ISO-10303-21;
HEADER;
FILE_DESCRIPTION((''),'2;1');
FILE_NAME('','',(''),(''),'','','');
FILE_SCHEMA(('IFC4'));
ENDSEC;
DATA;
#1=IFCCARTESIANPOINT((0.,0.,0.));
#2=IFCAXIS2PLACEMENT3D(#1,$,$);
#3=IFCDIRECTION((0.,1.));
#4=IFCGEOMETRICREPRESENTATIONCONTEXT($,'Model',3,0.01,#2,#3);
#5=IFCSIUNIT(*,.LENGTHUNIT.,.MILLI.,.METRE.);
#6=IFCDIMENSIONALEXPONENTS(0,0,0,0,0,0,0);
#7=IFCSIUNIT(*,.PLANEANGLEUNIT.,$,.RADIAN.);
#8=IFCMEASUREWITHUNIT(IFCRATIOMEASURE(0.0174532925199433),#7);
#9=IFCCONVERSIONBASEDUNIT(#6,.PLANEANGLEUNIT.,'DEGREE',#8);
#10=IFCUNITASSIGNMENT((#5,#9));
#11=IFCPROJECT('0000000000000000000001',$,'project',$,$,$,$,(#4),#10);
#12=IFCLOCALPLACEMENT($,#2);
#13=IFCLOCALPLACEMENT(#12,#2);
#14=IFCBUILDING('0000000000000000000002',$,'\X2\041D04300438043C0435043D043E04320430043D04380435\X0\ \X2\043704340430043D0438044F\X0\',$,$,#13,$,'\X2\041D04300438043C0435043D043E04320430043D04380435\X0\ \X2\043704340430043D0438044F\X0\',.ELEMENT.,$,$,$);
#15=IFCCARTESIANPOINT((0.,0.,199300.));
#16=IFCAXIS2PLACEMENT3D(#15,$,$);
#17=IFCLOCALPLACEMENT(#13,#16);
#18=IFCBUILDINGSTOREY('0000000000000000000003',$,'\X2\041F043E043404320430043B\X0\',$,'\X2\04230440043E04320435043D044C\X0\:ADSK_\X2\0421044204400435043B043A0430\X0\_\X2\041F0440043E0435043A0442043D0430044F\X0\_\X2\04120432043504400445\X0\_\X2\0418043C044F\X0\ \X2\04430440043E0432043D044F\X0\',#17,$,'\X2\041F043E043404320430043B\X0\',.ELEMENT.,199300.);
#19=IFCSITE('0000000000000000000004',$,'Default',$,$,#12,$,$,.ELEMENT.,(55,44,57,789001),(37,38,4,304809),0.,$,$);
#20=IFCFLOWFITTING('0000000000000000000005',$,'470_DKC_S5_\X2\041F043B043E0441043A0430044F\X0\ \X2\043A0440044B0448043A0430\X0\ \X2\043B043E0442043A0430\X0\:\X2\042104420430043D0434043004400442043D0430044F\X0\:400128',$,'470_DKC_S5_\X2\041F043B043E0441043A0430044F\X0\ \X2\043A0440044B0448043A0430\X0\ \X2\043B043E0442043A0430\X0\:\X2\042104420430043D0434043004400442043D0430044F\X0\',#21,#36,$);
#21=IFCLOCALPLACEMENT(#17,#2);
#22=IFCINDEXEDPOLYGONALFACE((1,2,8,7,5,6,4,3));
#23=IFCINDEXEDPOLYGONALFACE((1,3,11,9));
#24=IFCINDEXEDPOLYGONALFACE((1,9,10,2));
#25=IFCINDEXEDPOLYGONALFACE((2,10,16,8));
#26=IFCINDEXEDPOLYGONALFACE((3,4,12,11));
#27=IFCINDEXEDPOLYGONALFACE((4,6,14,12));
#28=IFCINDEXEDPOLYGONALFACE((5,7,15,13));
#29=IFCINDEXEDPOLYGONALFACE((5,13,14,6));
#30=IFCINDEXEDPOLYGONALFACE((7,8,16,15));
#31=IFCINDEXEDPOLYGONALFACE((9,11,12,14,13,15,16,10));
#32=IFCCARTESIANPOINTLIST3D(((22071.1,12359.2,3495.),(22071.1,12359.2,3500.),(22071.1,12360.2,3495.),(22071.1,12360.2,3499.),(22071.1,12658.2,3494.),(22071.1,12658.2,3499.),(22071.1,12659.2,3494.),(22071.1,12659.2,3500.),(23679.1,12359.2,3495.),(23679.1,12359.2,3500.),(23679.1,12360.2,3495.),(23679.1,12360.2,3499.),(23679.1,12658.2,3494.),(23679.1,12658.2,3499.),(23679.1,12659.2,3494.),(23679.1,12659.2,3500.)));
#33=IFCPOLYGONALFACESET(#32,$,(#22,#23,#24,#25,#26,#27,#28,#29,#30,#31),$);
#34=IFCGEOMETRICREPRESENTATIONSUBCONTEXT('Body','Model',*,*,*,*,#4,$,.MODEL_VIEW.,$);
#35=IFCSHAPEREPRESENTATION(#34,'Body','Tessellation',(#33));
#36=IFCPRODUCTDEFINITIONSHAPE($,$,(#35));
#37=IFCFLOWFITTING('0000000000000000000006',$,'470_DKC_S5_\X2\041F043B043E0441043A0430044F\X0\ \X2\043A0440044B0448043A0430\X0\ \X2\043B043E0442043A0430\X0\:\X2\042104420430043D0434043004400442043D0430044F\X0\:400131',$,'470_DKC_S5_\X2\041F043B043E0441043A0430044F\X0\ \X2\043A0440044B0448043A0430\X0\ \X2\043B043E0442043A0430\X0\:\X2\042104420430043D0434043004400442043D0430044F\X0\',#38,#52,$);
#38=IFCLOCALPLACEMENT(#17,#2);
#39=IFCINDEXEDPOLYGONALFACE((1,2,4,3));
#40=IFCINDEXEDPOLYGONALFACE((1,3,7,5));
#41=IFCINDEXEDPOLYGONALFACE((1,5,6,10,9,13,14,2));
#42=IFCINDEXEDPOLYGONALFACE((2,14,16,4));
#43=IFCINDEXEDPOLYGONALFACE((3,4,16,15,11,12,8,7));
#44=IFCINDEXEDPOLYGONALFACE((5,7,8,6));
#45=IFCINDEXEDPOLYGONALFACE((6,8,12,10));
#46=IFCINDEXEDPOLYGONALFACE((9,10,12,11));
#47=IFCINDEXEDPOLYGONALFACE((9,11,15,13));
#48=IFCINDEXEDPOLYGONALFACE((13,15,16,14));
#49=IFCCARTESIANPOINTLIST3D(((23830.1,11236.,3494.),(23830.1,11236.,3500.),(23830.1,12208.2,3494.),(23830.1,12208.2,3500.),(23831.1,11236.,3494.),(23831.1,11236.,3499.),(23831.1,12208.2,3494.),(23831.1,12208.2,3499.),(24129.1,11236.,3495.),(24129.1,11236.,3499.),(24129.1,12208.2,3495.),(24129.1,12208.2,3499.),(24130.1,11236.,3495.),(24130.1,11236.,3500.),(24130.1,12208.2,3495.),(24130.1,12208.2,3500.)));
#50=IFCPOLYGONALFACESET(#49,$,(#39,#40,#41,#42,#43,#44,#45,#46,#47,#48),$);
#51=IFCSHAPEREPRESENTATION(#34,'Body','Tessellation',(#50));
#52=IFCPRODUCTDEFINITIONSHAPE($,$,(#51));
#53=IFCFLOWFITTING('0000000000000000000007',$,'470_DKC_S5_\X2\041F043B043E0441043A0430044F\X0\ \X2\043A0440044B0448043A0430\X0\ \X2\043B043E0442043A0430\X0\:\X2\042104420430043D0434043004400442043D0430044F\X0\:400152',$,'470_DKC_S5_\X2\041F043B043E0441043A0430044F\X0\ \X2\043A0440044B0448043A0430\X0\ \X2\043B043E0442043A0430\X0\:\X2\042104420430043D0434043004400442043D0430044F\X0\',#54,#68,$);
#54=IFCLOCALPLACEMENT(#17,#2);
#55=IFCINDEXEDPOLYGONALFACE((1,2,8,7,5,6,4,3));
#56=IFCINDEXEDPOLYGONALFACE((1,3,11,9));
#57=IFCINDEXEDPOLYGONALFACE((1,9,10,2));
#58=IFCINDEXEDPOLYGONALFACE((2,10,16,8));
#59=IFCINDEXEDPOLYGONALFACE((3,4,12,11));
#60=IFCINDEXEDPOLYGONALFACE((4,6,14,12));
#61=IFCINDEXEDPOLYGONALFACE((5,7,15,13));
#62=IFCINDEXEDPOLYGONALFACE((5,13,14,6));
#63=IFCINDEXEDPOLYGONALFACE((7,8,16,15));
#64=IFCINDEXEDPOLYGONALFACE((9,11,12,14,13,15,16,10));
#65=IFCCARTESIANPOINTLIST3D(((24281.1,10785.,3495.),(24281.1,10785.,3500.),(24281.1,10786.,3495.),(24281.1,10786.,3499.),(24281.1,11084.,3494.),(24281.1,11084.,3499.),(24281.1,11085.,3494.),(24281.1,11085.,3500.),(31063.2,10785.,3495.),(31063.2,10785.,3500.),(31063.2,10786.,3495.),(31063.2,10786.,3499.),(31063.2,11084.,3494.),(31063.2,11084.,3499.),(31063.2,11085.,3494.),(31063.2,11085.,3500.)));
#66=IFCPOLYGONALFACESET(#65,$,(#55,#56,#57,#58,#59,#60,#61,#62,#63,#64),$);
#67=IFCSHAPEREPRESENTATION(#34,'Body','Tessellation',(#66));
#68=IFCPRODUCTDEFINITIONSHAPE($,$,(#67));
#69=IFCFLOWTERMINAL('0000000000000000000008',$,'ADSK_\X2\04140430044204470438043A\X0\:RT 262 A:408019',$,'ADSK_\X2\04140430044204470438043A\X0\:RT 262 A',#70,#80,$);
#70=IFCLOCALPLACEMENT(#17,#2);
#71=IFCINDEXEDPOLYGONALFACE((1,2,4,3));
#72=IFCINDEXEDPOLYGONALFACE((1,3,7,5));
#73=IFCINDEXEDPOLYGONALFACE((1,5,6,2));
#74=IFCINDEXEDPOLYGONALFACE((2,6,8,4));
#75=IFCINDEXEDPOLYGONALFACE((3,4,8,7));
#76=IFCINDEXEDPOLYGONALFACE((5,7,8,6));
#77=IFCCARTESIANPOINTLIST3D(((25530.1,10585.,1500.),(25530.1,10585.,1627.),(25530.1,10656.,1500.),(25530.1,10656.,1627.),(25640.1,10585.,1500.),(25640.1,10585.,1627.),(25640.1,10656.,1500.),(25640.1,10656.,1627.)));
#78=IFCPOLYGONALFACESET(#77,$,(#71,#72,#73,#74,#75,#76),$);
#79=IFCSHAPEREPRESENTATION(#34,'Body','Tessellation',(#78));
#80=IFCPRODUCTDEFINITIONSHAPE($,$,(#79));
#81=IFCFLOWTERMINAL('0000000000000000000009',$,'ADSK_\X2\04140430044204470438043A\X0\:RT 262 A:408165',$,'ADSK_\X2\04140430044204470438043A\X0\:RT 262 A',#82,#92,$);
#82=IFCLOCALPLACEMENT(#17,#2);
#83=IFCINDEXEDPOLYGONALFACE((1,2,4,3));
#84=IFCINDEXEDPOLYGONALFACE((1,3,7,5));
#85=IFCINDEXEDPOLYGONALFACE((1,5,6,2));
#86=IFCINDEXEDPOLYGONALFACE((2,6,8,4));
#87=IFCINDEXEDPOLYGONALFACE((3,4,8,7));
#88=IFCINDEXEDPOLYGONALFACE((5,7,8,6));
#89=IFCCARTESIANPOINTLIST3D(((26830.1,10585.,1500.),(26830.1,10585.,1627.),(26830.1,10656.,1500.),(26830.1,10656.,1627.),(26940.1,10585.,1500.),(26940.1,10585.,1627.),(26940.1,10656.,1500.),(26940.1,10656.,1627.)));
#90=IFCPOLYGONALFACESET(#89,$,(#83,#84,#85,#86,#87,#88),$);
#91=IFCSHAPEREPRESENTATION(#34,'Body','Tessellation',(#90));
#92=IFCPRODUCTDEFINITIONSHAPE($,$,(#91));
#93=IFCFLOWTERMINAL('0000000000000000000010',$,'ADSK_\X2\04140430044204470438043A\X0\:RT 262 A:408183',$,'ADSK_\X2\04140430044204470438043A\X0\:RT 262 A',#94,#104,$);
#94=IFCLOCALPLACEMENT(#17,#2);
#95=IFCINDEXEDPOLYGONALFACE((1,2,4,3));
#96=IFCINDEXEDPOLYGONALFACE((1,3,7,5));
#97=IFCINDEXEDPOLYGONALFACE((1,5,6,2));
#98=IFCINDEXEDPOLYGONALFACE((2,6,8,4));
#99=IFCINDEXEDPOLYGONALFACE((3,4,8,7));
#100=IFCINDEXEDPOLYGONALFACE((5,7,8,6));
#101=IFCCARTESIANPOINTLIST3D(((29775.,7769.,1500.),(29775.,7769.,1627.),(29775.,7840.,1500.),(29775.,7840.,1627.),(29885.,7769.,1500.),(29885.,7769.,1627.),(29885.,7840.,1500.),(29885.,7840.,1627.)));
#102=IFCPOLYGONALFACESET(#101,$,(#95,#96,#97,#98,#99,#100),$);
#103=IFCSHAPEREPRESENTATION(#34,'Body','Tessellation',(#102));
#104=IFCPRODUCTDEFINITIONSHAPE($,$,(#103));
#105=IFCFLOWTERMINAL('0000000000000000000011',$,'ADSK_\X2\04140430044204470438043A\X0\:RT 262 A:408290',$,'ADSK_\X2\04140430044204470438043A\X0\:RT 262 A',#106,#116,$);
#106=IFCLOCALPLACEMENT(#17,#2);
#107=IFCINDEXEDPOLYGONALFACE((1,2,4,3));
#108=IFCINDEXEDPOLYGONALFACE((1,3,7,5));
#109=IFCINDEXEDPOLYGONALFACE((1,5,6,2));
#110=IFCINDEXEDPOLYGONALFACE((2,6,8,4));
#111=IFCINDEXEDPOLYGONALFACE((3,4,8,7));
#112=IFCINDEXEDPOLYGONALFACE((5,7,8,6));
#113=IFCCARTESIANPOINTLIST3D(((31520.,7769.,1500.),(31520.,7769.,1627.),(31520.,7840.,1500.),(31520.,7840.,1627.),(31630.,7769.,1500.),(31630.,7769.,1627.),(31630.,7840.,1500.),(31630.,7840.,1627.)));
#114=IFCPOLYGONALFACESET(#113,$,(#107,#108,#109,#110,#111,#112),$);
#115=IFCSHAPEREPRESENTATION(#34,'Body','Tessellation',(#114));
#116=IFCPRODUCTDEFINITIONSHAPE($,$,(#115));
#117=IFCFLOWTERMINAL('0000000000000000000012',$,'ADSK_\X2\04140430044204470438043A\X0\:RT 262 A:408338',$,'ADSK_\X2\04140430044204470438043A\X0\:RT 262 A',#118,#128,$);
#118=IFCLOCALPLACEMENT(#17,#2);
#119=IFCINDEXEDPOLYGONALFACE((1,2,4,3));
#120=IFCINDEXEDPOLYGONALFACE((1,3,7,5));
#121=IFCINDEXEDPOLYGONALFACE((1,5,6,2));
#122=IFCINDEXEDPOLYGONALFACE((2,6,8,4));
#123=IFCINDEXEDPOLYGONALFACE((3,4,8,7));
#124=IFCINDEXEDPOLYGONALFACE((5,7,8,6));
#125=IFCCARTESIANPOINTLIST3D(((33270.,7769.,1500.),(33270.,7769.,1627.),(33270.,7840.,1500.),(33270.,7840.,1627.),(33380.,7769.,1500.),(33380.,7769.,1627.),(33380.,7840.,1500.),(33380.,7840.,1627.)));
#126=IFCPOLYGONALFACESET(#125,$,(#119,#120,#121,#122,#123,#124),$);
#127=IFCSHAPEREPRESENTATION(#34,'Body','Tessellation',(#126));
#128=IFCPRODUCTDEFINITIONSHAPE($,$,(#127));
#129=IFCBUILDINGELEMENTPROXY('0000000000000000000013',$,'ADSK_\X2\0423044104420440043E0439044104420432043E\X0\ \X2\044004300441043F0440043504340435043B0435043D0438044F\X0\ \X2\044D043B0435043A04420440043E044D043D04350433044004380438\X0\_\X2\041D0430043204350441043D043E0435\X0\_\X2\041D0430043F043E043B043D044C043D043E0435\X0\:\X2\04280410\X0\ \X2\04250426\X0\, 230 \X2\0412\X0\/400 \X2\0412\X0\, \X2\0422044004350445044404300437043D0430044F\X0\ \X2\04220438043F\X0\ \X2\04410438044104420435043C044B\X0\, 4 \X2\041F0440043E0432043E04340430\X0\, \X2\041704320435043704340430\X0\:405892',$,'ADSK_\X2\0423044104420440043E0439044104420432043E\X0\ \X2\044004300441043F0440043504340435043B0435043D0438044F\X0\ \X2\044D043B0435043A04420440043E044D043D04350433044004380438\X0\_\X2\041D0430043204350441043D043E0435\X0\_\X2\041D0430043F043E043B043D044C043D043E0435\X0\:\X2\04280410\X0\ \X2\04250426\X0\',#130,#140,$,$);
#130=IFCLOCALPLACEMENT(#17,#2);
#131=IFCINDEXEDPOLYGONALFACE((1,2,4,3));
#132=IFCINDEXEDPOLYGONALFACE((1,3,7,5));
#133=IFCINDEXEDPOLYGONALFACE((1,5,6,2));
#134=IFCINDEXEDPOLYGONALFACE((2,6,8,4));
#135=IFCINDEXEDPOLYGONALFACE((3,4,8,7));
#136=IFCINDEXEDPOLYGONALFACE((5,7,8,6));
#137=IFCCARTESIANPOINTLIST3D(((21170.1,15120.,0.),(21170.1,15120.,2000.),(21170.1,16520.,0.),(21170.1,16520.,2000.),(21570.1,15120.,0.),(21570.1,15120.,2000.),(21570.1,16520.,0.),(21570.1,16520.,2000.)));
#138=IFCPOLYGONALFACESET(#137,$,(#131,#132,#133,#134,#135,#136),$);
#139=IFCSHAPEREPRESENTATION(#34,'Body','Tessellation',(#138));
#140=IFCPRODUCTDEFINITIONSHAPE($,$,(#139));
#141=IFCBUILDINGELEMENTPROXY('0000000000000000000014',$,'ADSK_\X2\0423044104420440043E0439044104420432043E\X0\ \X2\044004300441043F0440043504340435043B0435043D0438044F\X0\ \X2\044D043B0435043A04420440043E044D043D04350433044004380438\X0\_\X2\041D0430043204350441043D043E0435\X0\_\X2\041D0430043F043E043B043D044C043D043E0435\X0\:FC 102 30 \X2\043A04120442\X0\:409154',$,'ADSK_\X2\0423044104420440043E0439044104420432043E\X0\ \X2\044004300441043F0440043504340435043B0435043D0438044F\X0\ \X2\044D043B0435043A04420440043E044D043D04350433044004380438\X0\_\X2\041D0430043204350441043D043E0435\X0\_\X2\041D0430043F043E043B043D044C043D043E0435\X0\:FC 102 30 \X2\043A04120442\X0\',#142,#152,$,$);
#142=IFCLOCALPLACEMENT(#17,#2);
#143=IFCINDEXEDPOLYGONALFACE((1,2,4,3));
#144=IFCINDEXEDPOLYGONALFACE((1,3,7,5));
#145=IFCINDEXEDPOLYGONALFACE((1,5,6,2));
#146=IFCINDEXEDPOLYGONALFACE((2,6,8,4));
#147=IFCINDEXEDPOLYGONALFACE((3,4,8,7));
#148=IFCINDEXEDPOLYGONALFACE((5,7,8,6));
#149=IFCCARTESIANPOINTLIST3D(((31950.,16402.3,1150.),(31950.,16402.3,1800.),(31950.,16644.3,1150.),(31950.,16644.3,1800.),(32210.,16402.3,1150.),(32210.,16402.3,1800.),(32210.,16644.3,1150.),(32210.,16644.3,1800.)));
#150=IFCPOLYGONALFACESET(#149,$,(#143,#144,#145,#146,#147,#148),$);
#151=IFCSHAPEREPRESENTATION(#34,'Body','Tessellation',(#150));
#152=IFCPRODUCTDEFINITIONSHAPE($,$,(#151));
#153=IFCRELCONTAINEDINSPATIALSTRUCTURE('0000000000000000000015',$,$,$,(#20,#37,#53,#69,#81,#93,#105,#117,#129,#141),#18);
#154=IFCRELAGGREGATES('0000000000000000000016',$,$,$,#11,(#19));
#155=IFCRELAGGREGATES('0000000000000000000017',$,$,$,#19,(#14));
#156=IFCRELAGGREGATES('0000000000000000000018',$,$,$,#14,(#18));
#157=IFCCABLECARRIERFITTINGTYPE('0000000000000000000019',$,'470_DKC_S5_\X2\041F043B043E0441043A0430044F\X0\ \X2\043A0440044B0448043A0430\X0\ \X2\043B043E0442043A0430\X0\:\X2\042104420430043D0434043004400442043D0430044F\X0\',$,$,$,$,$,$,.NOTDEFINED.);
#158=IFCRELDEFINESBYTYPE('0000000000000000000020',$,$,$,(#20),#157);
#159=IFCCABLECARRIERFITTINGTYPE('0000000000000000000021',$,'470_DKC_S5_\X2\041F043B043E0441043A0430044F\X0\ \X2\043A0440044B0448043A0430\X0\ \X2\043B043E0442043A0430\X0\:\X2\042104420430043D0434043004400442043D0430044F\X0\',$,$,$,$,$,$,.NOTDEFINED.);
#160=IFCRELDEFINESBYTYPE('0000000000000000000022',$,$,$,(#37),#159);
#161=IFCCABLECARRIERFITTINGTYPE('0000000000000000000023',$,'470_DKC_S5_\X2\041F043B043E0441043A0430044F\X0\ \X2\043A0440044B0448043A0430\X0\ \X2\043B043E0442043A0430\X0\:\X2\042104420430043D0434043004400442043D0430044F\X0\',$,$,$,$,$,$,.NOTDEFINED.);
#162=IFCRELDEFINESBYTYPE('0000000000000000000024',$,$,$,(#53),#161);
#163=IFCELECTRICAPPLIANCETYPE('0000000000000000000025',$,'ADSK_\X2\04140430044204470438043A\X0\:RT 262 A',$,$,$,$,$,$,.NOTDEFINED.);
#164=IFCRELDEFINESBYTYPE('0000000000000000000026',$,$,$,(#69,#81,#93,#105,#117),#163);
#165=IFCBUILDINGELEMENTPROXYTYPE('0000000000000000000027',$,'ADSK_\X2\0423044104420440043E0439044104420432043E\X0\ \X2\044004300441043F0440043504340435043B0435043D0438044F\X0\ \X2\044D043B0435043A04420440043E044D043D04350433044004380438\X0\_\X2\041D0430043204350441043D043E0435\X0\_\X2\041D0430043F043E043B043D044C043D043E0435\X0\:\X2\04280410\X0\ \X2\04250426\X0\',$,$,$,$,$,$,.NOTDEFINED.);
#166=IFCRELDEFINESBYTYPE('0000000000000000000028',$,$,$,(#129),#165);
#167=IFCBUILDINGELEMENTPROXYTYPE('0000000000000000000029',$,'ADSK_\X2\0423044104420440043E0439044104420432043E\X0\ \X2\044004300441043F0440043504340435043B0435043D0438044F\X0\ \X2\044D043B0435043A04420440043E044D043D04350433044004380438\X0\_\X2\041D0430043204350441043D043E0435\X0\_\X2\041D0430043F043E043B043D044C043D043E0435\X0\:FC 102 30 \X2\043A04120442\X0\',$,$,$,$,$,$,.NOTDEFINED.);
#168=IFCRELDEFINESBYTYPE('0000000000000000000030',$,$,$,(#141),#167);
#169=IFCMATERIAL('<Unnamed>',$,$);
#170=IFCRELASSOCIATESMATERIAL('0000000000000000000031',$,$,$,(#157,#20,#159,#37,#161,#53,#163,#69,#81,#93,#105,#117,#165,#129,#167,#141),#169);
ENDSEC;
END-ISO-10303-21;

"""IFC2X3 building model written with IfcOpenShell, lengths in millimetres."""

from ifc_helpers import new_model, entity, si_unit, converted_unit, direction, frame, origin, origin_2d_with_axis, place, context, subcontext, project, spatial, polyline, rectangle, outline, extrude, source, transform, mapped, material, type_object, type_shapes, element, save


model = new_model("IFC2X3")

# Units and contexts
model_context = context("Model", 3, precision=0.01, world=origin(), true_north=direction((0.0, 1.0)))
body_context = subcontext(model_context, "Body", "Model", "MODEL_VIEW")
ifc_project = project(units=[si_unit("LENGTHUNIT", "METRE", prefix="MILLI"), converted_unit("PLANEANGLEUNIT", "DEGREE", entity("IfcRatioMeasure", 0.0174532925199433), si_unit("PLANEANGLEUNIT", "RADIAN"), dimensions=[0, 0, 0, 0, 0, 0, 0])], contexts=[model_context])

# Site, building, storey
site_placement = place(None, origin())
site = spatial("IfcSite", under=ifc_project, at=site_placement, Name="Default", CompositionType="ELEMENT", RefLatitude=(55, 44, 57, 789001), RefLongitude=(37, 38, 4, 304809), RefElevation=0.0)
building_placement = place(site_placement, origin())
building = spatial("IfcBuilding", under=site, at=building_placement, Name="Наименование здания", LongName="Наименование здания", CompositionType="ELEMENT")
storey_placement = place(building_placement, frame((0.0, 0.0, 199300.0)))
storey = spatial("IfcBuildingStorey", under=building, at=storey_placement, Name="Подвал", ObjectType="Уровень:ADSK_Стрелка_Проектная_Вверх_Имя уровня", LongName="Подвал", CompositionType="ELEMENT", Elevation=199300.0)

# Flow fittings
ifc_material = material(Name="<Unnamed>")
cable_carrier_fitting_type_1 = type_object("IfcCableCarrierFittingType", Name="470_DKC_S5_Плоская крышка лотка:Стандартная", PredefinedType="NOTDEFINED", material=ifc_material)
shared_shape_1 = source(origin(), body_context, "Body", "SweptSolid", [
    extrude(outline(polyline([(-150.0, -2.0), (-149.0, -2.0), (-149.0, 2.0), (149.0, 2.0), (149.0, -3.0), (150.0, -3.0), (150.0, 3.0), (-150.0, 3.0), (-150.0, -2.0)])), frame((0.0, 150.0, 3.0), z_axis=(1.0, 0.0, 0.0), x_axis=(0.0, 1.0, 0.0)), (0.0, 0.0, 1.0), 1608.0),
])
type_shapes(cable_carrier_fitting_type_1, [shared_shape_1])
flow_fitting_1_placement = place(storey_placement, frame((22071.1, 12359.2, 3494.0)))
element("IfcFlowFitting", 1, at=flow_fitting_1_placement, inside=storey, type_object=cable_carrier_fitting_type_1, material=ifc_material, Name="470_DKC_S5_Плоская крышка лотка:Стандартная:400128", ObjectType="470_DKC_S5_Плоская крышка лотка:Стандартная", context=body_context, shape_type="MappedRepresentation", body=[
    mapped(shared_shape_1, transform((0.0, 0.0, 0.0), scale=1.0)),
])
cable_carrier_fitting_type_2 = type_object("IfcCableCarrierFittingType", Name="470_DKC_S5_Плоская крышка лотка:Стандартная", PredefinedType="NOTDEFINED", material=ifc_material)
shared_shape_2 = source(origin(), body_context, "Body", "SweptSolid", [
    extrude(outline(polyline([(-150.0, -2.0), (-149.0, -2.0), (-149.0, 2.0), (149.0, 2.0), (149.0, -3.0), (150.0, -3.0), (150.0, 3.0), (-150.0, 3.0), (-150.0, -2.0)])), frame((0.0, 150.0, 3.0), z_axis=(1.0, 0.0, 0.0), x_axis=(0.0, 1.0, 0.0)), (0.0, 0.0, 1.0), 972.2),
])
type_shapes(cable_carrier_fitting_type_2, [shared_shape_2])
flow_fitting_2_placement = place(storey_placement, frame((24130.1, 11236.0, 3494.0), z_axis=(0.0, 0.0, 1.0), x_axis=(0.0, 1.0, 0.0)))
element("IfcFlowFitting", 2, at=flow_fitting_2_placement, inside=storey, type_object=cable_carrier_fitting_type_2, material=ifc_material, Name="470_DKC_S5_Плоская крышка лотка:Стандартная:400131", ObjectType="470_DKC_S5_Плоская крышка лотка:Стандартная", context=body_context, shape_type="MappedRepresentation", body=[
    mapped(shared_shape_2, transform((0.0, 0.0, 0.0), scale=1.0)),
])
cable_carrier_fitting_type_3 = type_object("IfcCableCarrierFittingType", Name="470_DKC_S5_Плоская крышка лотка:Стандартная", PredefinedType="NOTDEFINED", material=ifc_material)
shared_shape_3 = source(origin(), body_context, "Body", "SweptSolid", [
    extrude(outline(polyline([(-150.0, -2.0), (-149.0, -2.0), (-149.0, 2.0), (149.0, 2.0), (149.0, -3.0), (150.0, -3.0), (150.0, 3.0), (-150.0, 3.0), (-150.0, -2.0)])), frame((0.0, 150.0, 3.0), z_axis=(1.0, 0.0, 0.0), x_axis=(0.0, 1.0, 0.0)), (0.0, 0.0, 1.0), 6782.1),
])
type_shapes(cable_carrier_fitting_type_3, [shared_shape_3])
flow_fitting_3_placement = place(storey_placement, frame((24281.1, 10785.0, 3494.0)))
element("IfcFlowFitting", 3, at=flow_fitting_3_placement, inside=storey, type_object=cable_carrier_fitting_type_3, material=ifc_material, Name="470_DKC_S5_Плоская крышка лотка:Стандартная:400152", ObjectType="470_DKC_S5_Плоская крышка лотка:Стандартная", context=body_context, shape_type="MappedRepresentation", body=[
    mapped(shared_shape_3, transform((0.0, 0.0, 0.0), scale=1.0)),
])

# Flow terminals
electric_appliance_type = type_object("IfcElectricApplianceType", Name="ADSK_Датчик:RT 262 A", PredefinedType="NOTDEFINED", material=ifc_material)
shared_shape_4 = source(origin(), body_context, "Body", "SweptSolid", [
    extrude(rectangle(XDim=71.0, YDim=110.0, at=origin_2d_with_axis()), frame((0.0, 0.0, 0.0), z_axis=(0.0, 0.0, 1.0), x_axis=(-1.0, 0.0, 0.0)), (0.0, 0.0, 1.0), 127.0),
])
type_shapes(electric_appliance_type, [shared_shape_4])
for number, where, z_axis, x_axis, name in (
    (4, (25585.1, 10620.5, 1500.0), (0.0, 0.0, 1.0), (0.0, 1.0, 0.0), "ADSK_Датчик:RT 262 A:408019"),
    (5, (26885.1, 10620.5, 1500.0), (0.0, 0.0, 1.0), (0.0, 1.0, 0.0), "ADSK_Датчик:RT 262 A:408165"),
    (6, (29830.0, 7804.5, 1500.0), (0.0, 0.0, 1.0), (0.0, -1.0, 0.0), "ADSK_Датчик:RT 262 A:408183"),
    (7, (31575.0, 7804.5, 1500.0), (0.0, 0.0, 1.0), (0.0, -1.0, 0.0), "ADSK_Датчик:RT 262 A:408290"),
    (8, (33325.0, 7804.5, 1500.0), (0.0, 0.0, 1.0), (0.0, -1.0, 0.0), "ADSK_Датчик:RT 262 A:408338"),
):
    element("IfcFlowTerminal", number, at=place(storey_placement, frame(where, z_axis=z_axis, x_axis=x_axis)), inside=storey, type_object=electric_appliance_type, material=ifc_material, Name=name, ObjectType="ADSK_Датчик:RT 262 A", context=body_context, shape_type="MappedRepresentation", body=[
        mapped(shared_shape_4, transform((0.0, 0.0, 0.0), scale=1.0)),
    ])

# Building element proxies
building_element_proxy_type_1 = type_object("IfcBuildingElementProxyType", Name="ADSK_Устройство распределения электроэнегрии_Навесное_Наполньное:ША ХЦ", PredefinedType="NOTDEFINED", material=ifc_material)
shared_shape_5 = source(origin(), body_context, "Body", "SweptSolid", [
    extrude(rectangle(XDim=1400.0, YDim=400.0, at=origin_2d_with_axis()), frame((0.0, 200.0, -2000.0), z_axis=(0.0, 0.0, 1.0), x_axis=(-1.0, 0.0, 0.0)), (0.0, 0.0, 1.0), 2000.0),
])
type_shapes(building_element_proxy_type_1, [shared_shape_5])
proxy_1_placement = place(storey_placement, frame((21170.1, 15820.0, 2000.0), z_axis=(0.0, 0.0, 1.0), x_axis=(0.0, -1.0, 0.0)))
element("IfcBuildingElementProxy", 9, at=proxy_1_placement, inside=storey, type_object=building_element_proxy_type_1, material=ifc_material, Name="ADSK_Устройство распределения электроэнегрии_Навесное_Наполньное:ША ХЦ, 230 В/400 В, Трехфазная Тип системы, 4 Провода, Звезда:405892", ObjectType="ADSK_Устройство распределения электроэнегрии_Навесное_Наполньное:ША ХЦ", context=body_context, shape_type="MappedRepresentation", body=[
    mapped(shared_shape_5, transform((0.0, 0.0, 0.0), scale=1.0)),
])
building_element_proxy_type_2 = type_object("IfcBuildingElementProxyType", Name="ADSK_Устройство распределения электроэнегрии_Навесное_Наполньное:FC 102 30 кВт", PredefinedType="NOTDEFINED", material=ifc_material)
shared_shape_6 = source(origin(), body_context, "Body", "SweptSolid", [
    extrude(rectangle(XDim=242.0, YDim=260.0, at=origin_2d_with_axis()), frame((0.0, 130.0, -650.0), z_axis=(0.0, 0.0, 1.0), x_axis=(-1.0, 0.0, 0.0)), (0.0, 0.0, 1.0), 650.0),
])
type_shapes(building_element_proxy_type_2, [shared_shape_6])
proxy_2_placement = place(storey_placement, frame((32210.0, 16523.3, 1800.0), z_axis=(0.0, 0.0, 1.0), x_axis=(0.0, 1.0, 0.0)))
element("IfcBuildingElementProxy", 10, at=proxy_2_placement, inside=storey, type_object=building_element_proxy_type_2, material=ifc_material, Name="ADSK_Устройство распределения электроэнегрии_Навесное_Наполньное:FC 102 30 кВт:409154", ObjectType="ADSK_Устройство распределения электроэнегрии_Навесное_Наполньное:FC 102 30 кВт", context=body_context, shape_type="MappedRepresentation", body=[
    mapped(shared_shape_6, transform((0.0, 0.0, 0.0), scale=1.0)),
])

save(model, "model.ifc")
